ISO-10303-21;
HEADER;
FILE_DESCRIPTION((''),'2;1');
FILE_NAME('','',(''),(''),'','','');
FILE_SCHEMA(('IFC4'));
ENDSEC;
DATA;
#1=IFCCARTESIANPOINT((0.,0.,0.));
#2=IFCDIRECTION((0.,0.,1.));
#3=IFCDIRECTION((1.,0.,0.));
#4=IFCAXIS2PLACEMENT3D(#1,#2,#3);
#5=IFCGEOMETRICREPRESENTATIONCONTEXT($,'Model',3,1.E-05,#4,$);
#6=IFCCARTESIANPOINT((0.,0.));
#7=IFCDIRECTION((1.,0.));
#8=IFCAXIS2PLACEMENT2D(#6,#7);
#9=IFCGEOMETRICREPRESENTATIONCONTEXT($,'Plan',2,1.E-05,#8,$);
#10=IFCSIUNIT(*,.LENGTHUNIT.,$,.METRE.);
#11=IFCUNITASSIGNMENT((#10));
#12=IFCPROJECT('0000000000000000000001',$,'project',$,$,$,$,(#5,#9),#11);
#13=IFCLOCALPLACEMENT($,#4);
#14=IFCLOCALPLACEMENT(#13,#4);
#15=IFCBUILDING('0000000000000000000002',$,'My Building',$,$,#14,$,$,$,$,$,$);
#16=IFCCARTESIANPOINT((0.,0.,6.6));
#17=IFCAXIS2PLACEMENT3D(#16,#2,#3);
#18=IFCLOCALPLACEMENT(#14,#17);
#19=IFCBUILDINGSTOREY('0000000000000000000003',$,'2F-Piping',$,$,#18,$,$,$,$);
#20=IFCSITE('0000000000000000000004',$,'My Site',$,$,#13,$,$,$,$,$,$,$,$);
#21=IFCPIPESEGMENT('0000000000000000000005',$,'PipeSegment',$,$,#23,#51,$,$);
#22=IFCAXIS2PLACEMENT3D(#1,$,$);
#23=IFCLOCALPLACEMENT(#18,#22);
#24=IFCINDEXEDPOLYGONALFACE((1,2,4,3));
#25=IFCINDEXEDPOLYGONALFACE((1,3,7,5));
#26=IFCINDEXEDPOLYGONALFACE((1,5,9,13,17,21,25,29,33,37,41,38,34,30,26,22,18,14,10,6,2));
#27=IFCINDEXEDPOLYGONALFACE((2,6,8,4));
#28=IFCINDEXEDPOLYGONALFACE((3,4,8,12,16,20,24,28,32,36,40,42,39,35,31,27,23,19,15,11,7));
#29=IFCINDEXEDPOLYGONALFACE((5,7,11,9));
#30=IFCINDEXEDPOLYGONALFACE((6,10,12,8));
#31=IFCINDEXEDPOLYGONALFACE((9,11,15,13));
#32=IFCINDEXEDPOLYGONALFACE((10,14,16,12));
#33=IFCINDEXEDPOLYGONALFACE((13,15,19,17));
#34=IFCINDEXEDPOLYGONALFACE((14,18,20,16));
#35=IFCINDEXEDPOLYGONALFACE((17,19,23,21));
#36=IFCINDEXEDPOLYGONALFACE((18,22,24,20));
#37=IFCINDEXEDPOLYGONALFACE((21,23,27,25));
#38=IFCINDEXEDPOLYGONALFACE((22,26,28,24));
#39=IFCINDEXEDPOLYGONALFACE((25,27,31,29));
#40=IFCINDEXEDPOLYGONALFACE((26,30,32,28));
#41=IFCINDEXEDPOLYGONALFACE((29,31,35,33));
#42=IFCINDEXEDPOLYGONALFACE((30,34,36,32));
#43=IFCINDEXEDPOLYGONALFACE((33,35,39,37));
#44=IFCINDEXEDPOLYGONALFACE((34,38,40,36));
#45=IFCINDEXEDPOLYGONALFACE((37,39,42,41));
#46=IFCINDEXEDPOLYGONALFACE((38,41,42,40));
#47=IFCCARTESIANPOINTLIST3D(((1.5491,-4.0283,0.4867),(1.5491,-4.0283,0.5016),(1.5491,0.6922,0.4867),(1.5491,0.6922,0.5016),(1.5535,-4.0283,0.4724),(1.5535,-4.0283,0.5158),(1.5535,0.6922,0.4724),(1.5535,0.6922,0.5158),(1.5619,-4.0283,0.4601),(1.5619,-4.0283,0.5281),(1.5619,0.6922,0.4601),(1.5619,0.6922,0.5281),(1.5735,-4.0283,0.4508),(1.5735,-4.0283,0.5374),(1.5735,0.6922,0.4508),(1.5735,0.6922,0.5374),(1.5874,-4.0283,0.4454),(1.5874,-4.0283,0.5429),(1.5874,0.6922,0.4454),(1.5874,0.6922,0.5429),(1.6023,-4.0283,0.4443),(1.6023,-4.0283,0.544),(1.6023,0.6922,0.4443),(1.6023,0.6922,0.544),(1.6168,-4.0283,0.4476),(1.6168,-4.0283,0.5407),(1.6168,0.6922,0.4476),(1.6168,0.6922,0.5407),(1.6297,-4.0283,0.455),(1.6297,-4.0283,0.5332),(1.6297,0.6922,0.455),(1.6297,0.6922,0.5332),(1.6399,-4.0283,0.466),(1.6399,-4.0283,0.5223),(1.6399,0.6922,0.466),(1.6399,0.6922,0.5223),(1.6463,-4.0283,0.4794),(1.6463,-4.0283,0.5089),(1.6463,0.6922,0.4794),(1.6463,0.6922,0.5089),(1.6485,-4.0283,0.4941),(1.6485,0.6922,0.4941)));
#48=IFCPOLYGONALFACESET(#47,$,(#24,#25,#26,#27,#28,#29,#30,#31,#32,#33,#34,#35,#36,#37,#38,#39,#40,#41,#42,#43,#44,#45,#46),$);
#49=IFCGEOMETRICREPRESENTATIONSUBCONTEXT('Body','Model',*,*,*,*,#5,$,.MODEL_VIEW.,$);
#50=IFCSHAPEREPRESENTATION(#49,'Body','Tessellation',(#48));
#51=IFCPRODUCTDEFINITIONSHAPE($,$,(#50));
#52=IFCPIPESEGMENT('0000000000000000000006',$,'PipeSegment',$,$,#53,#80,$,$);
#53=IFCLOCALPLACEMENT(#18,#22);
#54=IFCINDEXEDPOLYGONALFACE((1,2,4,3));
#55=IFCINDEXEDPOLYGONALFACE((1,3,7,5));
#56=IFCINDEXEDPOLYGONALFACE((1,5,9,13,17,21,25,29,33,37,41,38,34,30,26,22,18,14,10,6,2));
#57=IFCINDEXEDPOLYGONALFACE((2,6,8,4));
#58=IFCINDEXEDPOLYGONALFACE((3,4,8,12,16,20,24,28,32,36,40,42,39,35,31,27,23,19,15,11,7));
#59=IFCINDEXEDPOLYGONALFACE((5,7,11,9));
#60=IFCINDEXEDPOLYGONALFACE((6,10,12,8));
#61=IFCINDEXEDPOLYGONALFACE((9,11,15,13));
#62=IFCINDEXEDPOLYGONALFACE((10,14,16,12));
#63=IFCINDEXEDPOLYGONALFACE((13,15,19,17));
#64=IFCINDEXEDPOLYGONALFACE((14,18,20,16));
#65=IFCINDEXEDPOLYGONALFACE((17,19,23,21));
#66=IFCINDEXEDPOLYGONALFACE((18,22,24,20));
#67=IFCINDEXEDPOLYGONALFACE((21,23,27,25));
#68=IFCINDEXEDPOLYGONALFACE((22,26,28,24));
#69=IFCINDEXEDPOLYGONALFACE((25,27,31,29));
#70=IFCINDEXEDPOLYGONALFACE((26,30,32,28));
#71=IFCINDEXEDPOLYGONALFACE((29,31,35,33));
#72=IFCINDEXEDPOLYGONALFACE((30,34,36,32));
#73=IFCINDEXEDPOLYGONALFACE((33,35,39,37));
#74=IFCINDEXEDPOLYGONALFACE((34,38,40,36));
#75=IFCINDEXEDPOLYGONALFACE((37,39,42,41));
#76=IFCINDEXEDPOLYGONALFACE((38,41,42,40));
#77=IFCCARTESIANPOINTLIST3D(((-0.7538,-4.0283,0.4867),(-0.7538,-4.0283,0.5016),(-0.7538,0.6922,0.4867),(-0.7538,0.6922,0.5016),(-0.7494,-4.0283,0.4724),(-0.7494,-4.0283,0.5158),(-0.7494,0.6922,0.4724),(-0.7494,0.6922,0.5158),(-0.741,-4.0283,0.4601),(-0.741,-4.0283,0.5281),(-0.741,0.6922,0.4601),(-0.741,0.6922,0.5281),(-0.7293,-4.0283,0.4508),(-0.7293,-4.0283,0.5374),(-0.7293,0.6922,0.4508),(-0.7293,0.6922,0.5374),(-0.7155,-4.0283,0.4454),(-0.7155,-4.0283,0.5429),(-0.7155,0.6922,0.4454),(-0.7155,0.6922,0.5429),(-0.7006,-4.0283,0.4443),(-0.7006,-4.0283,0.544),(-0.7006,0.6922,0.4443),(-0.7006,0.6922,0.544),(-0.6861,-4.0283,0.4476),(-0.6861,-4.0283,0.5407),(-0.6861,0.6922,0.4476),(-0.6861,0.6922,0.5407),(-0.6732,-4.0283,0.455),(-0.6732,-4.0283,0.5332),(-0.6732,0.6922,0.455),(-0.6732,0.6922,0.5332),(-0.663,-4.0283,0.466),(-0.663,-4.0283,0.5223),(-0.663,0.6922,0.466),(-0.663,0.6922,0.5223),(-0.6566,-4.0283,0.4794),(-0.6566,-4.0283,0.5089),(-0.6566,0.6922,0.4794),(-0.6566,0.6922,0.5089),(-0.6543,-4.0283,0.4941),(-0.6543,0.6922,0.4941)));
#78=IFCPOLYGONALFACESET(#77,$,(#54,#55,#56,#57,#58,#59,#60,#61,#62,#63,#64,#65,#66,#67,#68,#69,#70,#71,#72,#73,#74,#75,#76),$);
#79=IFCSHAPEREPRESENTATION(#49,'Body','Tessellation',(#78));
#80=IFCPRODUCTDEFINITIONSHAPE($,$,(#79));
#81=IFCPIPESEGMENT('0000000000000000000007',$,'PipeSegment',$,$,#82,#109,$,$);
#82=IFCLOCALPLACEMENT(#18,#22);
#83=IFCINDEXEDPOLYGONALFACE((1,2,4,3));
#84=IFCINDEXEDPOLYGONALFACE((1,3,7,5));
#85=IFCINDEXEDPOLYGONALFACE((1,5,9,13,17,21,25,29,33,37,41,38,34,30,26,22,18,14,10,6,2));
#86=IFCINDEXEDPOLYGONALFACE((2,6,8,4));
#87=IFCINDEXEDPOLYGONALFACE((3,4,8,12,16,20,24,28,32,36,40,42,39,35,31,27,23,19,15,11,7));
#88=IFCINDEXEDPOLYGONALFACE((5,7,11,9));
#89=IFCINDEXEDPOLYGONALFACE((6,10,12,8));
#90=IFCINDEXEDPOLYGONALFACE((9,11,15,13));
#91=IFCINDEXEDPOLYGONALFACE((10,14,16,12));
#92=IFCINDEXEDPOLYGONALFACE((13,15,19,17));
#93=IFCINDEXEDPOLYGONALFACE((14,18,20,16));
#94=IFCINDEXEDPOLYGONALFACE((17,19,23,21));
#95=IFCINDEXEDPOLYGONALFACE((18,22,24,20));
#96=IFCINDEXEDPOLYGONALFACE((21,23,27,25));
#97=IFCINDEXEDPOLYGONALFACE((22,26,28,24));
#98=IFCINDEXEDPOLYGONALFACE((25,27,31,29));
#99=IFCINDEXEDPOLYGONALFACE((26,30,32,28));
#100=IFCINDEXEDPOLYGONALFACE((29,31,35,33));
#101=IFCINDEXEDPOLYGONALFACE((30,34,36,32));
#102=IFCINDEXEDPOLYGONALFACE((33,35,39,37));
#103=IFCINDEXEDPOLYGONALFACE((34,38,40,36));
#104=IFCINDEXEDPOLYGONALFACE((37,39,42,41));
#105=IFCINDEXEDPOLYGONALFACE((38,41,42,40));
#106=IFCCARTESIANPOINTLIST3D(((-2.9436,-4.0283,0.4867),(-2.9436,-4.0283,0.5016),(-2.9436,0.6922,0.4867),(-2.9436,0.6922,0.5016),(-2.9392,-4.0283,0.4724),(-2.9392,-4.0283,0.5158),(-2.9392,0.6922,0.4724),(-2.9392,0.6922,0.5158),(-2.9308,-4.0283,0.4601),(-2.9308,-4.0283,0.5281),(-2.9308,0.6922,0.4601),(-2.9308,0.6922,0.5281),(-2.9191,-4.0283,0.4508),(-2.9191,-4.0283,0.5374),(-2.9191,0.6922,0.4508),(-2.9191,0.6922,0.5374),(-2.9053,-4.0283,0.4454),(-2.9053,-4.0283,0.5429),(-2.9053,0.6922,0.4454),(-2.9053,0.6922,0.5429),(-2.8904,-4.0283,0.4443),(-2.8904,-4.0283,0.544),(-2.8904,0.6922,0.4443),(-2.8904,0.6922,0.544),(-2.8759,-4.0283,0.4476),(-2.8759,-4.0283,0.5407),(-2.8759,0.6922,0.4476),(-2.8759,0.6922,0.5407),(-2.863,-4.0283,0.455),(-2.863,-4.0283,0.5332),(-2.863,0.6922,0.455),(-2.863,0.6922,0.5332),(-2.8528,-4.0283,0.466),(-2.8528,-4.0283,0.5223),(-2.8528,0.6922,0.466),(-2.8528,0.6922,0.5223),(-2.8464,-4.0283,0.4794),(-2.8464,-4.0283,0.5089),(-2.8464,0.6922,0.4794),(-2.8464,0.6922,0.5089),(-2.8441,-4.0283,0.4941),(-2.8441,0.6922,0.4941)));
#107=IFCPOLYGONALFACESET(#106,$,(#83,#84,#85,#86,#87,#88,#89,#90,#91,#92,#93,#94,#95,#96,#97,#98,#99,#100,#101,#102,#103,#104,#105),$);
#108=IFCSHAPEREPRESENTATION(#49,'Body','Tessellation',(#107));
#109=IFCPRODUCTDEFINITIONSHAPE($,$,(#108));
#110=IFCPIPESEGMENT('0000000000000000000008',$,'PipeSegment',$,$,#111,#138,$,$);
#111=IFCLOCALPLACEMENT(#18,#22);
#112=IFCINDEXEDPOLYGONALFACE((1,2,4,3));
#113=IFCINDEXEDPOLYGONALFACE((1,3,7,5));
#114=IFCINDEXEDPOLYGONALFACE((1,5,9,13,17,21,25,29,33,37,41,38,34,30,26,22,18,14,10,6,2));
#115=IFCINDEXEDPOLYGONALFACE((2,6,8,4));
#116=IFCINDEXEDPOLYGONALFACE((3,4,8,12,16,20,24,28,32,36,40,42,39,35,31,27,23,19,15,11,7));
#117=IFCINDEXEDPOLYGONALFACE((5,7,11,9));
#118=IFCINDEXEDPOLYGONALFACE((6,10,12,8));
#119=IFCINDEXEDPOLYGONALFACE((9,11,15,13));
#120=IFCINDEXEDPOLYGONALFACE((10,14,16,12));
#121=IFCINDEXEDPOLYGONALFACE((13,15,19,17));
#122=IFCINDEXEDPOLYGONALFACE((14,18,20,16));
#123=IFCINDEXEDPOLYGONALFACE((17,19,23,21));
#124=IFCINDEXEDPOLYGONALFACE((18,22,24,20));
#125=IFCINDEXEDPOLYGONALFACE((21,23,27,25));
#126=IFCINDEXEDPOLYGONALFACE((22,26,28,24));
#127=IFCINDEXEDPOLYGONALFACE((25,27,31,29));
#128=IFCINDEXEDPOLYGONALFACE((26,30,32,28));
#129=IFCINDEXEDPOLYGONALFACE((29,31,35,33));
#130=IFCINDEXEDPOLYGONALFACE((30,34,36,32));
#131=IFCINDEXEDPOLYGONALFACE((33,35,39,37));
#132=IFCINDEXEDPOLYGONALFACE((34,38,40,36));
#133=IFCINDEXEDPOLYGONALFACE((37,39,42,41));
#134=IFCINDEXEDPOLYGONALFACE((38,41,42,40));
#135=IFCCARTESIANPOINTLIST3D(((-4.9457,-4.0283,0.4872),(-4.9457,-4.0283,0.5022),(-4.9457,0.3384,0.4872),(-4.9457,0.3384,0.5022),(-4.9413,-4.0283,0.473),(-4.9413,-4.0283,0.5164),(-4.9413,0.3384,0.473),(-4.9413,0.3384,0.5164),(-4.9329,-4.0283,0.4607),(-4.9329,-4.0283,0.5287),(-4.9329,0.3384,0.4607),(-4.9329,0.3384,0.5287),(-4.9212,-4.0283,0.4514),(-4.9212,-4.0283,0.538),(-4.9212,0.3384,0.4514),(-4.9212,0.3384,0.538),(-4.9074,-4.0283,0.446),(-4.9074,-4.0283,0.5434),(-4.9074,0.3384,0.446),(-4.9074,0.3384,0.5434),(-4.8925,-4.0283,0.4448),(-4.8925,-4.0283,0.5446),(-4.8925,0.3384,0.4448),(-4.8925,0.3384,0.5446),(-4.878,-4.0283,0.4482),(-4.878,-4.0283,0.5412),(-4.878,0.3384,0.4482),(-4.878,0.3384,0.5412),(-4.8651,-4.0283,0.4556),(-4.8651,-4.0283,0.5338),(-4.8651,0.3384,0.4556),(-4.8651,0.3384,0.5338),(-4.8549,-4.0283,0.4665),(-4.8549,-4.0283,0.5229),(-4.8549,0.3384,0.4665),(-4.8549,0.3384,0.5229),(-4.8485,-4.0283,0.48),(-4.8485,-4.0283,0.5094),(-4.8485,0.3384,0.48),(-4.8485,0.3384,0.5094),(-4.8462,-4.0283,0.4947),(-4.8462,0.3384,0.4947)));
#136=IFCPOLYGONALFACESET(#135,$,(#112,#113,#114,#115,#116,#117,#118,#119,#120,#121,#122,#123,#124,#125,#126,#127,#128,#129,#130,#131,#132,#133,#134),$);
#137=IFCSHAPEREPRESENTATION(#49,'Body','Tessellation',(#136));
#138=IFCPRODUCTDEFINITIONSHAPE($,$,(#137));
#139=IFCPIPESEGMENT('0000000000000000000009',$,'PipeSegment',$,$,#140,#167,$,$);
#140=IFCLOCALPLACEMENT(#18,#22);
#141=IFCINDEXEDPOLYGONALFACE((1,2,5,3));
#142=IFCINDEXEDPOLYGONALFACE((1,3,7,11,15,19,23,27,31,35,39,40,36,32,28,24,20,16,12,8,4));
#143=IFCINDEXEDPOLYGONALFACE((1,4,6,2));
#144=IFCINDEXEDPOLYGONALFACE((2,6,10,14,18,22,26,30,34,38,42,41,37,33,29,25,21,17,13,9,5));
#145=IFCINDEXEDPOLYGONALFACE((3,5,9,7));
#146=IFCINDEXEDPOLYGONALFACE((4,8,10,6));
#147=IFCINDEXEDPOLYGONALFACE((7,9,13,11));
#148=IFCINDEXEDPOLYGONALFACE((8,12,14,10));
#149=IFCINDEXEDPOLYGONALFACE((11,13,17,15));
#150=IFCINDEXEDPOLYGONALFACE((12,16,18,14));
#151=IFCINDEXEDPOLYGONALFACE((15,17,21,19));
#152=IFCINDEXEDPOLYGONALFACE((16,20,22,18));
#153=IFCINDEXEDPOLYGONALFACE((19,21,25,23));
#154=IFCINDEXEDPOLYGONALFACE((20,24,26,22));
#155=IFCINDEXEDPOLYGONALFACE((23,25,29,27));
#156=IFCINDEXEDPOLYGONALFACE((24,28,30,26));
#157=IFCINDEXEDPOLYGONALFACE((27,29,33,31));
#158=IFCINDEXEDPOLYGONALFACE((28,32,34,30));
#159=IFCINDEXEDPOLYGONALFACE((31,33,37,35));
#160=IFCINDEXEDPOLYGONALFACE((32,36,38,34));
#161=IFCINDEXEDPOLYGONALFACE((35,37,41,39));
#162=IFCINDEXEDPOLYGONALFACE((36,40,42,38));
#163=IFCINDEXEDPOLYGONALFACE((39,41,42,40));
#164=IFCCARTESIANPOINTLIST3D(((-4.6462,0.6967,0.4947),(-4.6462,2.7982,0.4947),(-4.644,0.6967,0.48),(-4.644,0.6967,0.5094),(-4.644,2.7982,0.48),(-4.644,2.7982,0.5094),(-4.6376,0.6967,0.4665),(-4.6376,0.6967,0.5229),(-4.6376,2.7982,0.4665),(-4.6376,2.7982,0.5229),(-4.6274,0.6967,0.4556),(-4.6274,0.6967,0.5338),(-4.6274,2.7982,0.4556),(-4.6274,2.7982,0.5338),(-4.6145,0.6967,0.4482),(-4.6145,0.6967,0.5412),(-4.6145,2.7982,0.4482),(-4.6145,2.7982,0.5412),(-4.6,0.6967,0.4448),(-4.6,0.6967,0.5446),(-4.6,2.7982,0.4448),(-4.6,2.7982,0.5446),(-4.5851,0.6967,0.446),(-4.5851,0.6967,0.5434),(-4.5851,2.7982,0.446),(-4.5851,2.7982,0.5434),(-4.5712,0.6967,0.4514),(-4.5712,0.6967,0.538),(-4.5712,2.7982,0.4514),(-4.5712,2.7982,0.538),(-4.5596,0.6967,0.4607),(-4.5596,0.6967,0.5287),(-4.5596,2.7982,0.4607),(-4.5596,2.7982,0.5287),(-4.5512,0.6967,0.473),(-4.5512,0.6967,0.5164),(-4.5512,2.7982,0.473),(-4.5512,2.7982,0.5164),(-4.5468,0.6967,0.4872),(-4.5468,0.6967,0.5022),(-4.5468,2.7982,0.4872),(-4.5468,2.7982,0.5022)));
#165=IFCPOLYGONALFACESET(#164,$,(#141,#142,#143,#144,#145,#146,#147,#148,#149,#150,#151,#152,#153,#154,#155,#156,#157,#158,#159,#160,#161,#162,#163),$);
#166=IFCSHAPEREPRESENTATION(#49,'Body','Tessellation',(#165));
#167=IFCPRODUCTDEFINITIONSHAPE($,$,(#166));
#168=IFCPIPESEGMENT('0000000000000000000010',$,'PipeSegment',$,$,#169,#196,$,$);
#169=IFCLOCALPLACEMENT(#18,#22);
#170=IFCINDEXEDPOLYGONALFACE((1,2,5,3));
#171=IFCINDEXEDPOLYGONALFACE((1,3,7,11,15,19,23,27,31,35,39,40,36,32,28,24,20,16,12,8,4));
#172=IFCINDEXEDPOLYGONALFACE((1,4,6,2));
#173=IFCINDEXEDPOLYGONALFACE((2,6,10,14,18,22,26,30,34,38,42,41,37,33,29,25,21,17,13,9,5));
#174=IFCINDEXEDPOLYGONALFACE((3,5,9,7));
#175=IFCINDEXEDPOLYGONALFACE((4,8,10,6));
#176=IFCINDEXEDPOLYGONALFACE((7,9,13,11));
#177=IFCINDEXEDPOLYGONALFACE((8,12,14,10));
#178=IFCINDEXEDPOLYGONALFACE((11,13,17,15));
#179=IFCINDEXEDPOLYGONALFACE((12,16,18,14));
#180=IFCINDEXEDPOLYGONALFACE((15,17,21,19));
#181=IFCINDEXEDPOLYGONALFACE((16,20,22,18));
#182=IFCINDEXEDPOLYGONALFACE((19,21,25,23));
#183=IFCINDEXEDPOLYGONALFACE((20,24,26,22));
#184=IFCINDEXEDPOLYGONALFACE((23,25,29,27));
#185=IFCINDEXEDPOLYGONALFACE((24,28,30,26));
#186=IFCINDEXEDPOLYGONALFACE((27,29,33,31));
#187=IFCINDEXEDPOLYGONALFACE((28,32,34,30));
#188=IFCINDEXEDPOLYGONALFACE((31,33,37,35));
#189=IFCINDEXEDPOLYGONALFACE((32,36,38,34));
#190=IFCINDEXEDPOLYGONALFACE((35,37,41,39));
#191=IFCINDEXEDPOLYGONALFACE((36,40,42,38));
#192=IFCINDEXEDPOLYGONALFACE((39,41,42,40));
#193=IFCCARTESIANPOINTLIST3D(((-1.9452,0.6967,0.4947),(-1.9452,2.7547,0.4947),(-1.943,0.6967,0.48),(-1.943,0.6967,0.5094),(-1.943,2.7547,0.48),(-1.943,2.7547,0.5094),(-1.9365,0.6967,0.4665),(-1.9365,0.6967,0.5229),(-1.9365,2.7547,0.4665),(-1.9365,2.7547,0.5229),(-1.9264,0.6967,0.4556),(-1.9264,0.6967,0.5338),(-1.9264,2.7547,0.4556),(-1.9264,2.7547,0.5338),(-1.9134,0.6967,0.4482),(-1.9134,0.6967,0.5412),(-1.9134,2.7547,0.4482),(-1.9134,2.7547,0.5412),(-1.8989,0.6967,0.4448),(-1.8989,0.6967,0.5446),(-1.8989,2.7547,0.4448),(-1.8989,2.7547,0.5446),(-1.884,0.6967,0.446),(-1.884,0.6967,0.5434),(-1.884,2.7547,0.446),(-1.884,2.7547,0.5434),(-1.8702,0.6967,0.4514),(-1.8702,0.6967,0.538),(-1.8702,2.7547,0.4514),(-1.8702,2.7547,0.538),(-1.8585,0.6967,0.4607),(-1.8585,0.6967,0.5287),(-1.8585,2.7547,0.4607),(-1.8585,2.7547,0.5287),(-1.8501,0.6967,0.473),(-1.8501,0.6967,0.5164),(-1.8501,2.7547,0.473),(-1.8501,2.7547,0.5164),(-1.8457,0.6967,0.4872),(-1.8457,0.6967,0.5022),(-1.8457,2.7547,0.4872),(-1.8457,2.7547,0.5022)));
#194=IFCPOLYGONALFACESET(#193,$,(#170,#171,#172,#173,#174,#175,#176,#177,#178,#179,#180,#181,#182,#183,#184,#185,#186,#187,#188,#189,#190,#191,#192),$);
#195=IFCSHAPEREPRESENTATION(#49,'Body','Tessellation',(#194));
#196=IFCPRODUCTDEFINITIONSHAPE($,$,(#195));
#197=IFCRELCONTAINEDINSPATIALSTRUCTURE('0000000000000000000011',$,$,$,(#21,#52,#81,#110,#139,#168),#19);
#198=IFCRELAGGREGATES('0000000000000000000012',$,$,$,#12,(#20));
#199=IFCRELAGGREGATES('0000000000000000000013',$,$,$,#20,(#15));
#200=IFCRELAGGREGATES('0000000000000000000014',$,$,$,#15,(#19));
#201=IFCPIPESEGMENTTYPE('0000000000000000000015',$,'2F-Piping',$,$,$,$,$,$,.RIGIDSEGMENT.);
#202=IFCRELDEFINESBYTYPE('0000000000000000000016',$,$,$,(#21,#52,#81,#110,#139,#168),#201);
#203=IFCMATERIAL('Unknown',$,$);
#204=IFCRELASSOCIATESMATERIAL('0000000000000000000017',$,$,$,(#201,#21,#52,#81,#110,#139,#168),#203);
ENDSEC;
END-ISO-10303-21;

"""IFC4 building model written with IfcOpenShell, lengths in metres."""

from ifc_helpers import new_model, si_unit, frame, origin_with_axes, origin_2d_with_axis, place, context, subcontext, project, spatial, circle, extrude, material, material_profile, profile_set, profile_usage, type_object, element, save


model = new_model("IFC4")

# Units and contexts
model_context = context("Model", 3, precision=1e-05, world=origin_with_axes())
plan_context = context("Plan", 2, precision=1e-05, world=origin_2d_with_axis())
body_context = subcontext(model_context, "Body", "Model", "MODEL_VIEW")
ifc_project = project(units=[si_unit("LENGTHUNIT", "METRE")], contexts=[model_context, plan_context])

# Site, building, storey
site_placement = place(None, origin_with_axes())
site = spatial("IfcSite", under=ifc_project, at=site_placement, Name="My Site")
building_placement = place(site_placement, origin_with_axes())
building = spatial("IfcBuilding", under=site, at=building_placement, Name="My Building")
storey_placement = place(building_placement, frame((0.0, 0.0, 6.6), z_axis=(0.0, 0.0, 1.0), x_axis=(1.0, 0.0, 0.0)))
storey = spatial("IfcBuildingStorey", under=building, at=storey_placement, Name="2F-Piping")

# Pipe segments
ifc_material = material(Name="Unknown")
ifc_material_profile = material_profile(ifc_material, circle(Radius=0.05))
ifc_profile_set = profile_set([ifc_material_profile])
ifc_profile_usage_1 = profile_usage(ifc_profile_set, cardinal=5)
pipe_segment_type = type_object("IfcPipeSegmentType", Name="2F-Piping", PredefinedType="RIGIDSEGMENT", material=ifc_profile_set)
pipe_segment_1_placement = place(storey_placement, frame((1.5985, 0.6922, 0.4941), z_axis=(0.0, -1.0, 0.0), x_axis=(1.0, 0.0, 0.0)))
element("IfcPipeSegment", 1, at=pipe_segment_1_placement, inside=storey, type_object=pipe_segment_type, material=ifc_profile_usage_1, Name="PipeSegment", context=body_context, shape_type="SweptSolid", body=[
    extrude(circle(Radius=0.05), origin_with_axes(), (0.0, 0.0, 1.0), 4.7204),
])
ifc_profile_usage_2 = profile_usage(ifc_profile_set, cardinal=5)
pipe_segment_2_placement = place(storey_placement, frame((-0.7043, 0.6922, 0.4941), z_axis=(0.0, -1.0, 0.0), x_axis=(1.0, 0.0, 0.0)))
element("IfcPipeSegment", 2, at=pipe_segment_2_placement, inside=storey, type_object=pipe_segment_type, material=ifc_profile_usage_2, Name="PipeSegment", context=body_context, shape_type="SweptSolid", body=[
    extrude(circle(Radius=0.05), origin_with_axes(), (0.0, 0.0, 1.0), 4.7204),
])
ifc_profile_usage_3 = profile_usage(ifc_profile_set, cardinal=5)
pipe_segment_3_placement = place(storey_placement, frame((-2.8941, 0.6922, 0.4941), z_axis=(0.0, -1.0, 0.0), x_axis=(1.0, 0.0, 0.0)))
element("IfcPipeSegment", 3, at=pipe_segment_3_placement, inside=storey, type_object=pipe_segment_type, material=ifc_profile_usage_3, Name="PipeSegment", context=body_context, shape_type="SweptSolid", body=[
    extrude(circle(Radius=0.05), origin_with_axes(), (0.0, 0.0, 1.0), 4.7204),
])
ifc_profile_usage_4 = profile_usage(ifc_profile_set, cardinal=5)
pipe_segment_4_placement = place(storey_placement, frame((-4.8962, 0.3384, 0.4947), z_axis=(0.0, -1.0, 0.0), x_axis=(1.0, 0.0, 0.0)))
element("IfcPipeSegment", 4, at=pipe_segment_4_placement, inside=storey, type_object=pipe_segment_type, material=ifc_profile_usage_4, Name="PipeSegment", context=body_context, shape_type="SweptSolid", body=[
    extrude(circle(Radius=0.05), origin_with_axes(), (0.0, 0.0, 1.0), 4.3667),
])
ifc_profile_usage_5 = profile_usage(ifc_profile_set, cardinal=5)
pipe_segment_5_placement = place(storey_placement, frame((-4.5962, 0.6967, 0.4947), z_axis=(0.0, 1.0, 0.0), x_axis=(-1.0, 0.0, 0.0)))
element("IfcPipeSegment", 5, at=pipe_segment_5_placement, inside=storey, type_object=pipe_segment_type, material=ifc_profile_usage_5, Name="PipeSegment", context=body_context, shape_type="SweptSolid", body=[
    extrude(circle(Radius=0.05), origin_with_axes(), (0.0, 0.0, 1.0), 2.1015),
])
ifc_profile_usage_6 = profile_usage(ifc_profile_set, cardinal=5)
pipe_segment_6_placement = place(storey_placement, frame((-1.8952, 0.6967, 0.4947), z_axis=(0.0, 1.0, 0.0), x_axis=(-1.0, 0.0, 0.0)))
element("IfcPipeSegment", 6, at=pipe_segment_6_placement, inside=storey, type_object=pipe_segment_type, material=ifc_profile_usage_6, Name="PipeSegment", context=body_context, shape_type="SweptSolid", body=[
    extrude(circle(Radius=0.05), origin_with_axes(), (0.0, 0.0, 1.0), 2.058),
])

save(model, "model.ifc")
